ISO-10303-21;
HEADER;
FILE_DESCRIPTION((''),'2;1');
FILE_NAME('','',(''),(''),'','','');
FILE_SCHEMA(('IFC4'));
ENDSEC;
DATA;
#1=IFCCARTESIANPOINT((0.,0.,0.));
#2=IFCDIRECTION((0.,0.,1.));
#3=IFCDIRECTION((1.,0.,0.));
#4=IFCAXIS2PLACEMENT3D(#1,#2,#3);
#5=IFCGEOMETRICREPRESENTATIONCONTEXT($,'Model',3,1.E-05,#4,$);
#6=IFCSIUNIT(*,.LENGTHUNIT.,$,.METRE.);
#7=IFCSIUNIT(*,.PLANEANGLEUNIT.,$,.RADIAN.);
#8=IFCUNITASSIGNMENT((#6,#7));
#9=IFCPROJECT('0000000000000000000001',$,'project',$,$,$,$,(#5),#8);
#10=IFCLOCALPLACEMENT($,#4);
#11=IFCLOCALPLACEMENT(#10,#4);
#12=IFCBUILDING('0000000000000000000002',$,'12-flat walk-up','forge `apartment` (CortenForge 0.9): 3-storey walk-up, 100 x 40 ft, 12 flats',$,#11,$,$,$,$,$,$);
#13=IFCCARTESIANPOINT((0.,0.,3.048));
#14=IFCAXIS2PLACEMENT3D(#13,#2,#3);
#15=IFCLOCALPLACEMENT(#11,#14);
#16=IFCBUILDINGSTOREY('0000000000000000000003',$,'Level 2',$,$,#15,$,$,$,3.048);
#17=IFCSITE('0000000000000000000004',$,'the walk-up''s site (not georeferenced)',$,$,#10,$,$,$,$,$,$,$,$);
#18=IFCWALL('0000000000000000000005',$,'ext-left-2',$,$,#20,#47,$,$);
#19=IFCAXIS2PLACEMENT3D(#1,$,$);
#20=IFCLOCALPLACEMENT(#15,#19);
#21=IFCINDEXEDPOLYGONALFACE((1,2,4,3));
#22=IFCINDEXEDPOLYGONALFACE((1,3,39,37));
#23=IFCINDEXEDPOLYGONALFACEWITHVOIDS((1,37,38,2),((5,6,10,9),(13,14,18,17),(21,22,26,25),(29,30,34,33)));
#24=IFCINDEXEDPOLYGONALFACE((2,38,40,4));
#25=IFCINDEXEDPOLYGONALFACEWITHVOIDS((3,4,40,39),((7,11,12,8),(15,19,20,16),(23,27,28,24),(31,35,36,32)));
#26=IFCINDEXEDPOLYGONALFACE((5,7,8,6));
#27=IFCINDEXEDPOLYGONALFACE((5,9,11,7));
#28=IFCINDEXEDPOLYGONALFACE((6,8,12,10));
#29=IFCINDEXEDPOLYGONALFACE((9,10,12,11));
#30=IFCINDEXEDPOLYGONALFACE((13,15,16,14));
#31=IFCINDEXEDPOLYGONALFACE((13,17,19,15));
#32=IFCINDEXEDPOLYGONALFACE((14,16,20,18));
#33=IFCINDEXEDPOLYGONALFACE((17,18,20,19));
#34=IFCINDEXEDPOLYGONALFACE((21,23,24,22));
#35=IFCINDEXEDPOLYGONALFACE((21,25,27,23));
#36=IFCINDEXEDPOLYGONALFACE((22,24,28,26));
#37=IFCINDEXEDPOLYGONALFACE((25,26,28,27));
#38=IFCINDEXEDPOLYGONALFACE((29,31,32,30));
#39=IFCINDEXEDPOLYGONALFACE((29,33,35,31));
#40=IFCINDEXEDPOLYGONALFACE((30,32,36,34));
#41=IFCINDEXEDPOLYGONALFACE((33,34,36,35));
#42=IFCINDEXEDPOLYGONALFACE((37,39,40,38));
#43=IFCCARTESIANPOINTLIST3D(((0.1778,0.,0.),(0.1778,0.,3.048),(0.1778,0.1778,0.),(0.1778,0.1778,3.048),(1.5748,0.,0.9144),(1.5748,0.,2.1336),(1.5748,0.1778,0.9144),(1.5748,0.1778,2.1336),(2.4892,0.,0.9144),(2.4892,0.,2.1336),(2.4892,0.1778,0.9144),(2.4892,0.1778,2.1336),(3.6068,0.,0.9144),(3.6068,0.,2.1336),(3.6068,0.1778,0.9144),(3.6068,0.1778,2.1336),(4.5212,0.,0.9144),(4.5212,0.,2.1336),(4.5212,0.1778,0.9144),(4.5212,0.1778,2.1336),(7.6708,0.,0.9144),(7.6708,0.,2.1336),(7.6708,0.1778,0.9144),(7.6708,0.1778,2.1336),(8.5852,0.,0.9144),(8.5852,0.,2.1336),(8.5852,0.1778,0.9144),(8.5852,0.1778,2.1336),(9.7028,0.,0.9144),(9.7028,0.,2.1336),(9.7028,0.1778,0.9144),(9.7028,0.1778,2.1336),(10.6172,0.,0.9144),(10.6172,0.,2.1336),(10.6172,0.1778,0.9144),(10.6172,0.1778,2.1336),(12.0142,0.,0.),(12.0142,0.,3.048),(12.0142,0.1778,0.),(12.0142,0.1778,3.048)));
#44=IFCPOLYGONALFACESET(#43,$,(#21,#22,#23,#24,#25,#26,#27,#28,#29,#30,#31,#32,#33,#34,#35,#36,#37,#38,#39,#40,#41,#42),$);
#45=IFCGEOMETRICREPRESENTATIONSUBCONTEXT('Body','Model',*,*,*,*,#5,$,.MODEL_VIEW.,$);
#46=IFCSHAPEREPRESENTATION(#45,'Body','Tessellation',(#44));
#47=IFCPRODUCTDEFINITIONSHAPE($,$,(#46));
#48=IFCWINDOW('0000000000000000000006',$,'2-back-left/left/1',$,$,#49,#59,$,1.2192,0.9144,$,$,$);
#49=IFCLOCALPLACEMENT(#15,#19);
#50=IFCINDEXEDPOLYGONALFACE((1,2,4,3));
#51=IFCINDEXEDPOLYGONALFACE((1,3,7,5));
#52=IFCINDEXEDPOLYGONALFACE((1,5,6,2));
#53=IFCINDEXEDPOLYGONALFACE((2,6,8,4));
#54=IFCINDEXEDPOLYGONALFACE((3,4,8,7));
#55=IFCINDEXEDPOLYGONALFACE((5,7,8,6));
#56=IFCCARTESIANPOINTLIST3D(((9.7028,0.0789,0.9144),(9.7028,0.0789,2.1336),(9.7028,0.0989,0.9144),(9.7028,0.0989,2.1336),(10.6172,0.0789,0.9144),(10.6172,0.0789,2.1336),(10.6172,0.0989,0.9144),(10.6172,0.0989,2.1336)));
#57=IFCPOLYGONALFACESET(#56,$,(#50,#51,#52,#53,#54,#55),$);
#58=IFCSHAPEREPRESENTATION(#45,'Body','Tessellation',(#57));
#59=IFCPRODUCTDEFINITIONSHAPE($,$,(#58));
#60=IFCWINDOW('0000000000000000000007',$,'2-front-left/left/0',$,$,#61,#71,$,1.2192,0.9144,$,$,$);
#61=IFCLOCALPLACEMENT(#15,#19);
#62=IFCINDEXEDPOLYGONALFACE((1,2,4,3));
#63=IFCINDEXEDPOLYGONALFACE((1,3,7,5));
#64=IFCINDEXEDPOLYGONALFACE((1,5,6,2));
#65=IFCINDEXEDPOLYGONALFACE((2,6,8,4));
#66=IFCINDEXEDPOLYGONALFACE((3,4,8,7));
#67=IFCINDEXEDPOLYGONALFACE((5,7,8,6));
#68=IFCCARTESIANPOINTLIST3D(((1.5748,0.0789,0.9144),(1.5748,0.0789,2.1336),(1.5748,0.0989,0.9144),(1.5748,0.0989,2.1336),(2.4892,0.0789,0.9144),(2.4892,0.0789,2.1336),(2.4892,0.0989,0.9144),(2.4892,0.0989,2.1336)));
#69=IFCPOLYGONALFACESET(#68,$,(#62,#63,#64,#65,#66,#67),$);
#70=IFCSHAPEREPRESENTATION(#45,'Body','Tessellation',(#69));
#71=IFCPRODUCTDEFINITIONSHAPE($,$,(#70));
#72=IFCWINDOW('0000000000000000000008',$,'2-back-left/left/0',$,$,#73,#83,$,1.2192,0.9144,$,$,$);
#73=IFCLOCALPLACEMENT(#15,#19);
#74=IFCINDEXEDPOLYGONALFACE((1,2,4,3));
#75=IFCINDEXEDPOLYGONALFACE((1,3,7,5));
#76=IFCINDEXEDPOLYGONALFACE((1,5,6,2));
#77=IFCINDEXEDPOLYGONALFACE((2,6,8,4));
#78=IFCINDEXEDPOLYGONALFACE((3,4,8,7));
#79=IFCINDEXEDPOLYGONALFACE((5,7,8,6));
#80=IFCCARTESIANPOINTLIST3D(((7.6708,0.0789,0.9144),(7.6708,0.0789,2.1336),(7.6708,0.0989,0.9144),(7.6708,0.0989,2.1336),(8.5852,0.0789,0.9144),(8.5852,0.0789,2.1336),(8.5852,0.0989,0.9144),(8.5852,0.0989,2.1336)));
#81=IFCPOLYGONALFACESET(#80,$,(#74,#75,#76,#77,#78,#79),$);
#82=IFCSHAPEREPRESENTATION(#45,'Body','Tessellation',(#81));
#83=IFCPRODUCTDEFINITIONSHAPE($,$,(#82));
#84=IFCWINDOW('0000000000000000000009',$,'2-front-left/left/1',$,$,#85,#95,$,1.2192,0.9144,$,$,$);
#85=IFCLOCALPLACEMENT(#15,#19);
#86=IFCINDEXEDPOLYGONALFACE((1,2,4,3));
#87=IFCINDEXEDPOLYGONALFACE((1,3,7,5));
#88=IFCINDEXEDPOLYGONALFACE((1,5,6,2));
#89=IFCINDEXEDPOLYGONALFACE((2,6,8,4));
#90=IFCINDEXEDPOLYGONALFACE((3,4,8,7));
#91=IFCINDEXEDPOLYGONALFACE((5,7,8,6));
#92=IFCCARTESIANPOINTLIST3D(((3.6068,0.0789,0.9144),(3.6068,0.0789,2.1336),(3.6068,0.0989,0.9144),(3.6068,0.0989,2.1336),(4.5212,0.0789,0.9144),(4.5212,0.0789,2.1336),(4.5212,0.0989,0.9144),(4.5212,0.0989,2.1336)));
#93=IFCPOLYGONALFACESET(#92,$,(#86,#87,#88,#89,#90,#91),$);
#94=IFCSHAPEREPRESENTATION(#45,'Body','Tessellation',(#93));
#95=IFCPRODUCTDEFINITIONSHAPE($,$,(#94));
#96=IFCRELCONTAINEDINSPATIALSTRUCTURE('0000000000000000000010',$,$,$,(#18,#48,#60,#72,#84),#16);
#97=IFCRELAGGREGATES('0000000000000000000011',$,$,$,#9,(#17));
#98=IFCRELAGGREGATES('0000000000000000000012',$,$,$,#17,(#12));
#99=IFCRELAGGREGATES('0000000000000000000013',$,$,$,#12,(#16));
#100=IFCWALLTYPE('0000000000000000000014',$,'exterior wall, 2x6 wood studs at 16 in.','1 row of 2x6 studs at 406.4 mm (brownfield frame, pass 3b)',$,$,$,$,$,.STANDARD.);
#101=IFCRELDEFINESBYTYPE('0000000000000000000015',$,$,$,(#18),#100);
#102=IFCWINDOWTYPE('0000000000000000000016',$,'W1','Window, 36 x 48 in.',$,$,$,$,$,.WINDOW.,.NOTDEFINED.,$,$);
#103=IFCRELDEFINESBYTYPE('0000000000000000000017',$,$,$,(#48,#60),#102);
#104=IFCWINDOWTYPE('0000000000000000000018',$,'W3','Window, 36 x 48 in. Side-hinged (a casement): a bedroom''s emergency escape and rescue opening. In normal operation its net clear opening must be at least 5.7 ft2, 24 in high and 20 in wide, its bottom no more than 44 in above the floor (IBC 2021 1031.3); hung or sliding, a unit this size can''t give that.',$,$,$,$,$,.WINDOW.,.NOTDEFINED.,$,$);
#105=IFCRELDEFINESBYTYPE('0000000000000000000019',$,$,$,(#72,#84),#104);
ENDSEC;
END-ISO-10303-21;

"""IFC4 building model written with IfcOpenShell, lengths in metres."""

from ifc_helpers import new_model, si_unit, frame, frame_2d, origin, origin_with_axes, place, context, subcontext, project, spatial, rectangle, extrude, type_object, element, fill, save


model = new_model("IFC4")

# Units and contexts
model_context = context("Model", 3, precision=1e-05, world=origin_with_axes())
body_context = subcontext(model_context, "Body", "Model", "MODEL_VIEW")
ifc_project = project(units=[si_unit("LENGTHUNIT", "METRE"), si_unit("PLANEANGLEUNIT", "RADIAN")], contexts=[model_context])

# Site, building, storey
site_placement = place(None, origin_with_axes())
site = spatial("IfcSite", under=ifc_project, at=site_placement, Name="the walk-up's site (not georeferenced)")
building_placement = place(site_placement, origin_with_axes())
building = spatial("IfcBuilding", under=site, at=building_placement, Name="12-flat walk-up", Description="forge `apartment` (CortenForge 0.9): 3-storey walk-up, 100 x 40 ft, 12 flats")
storey_placement = place(building_placement, frame((0.0, 0.0, 3.048), z_axis=(0.0, 0.0, 1.0), x_axis=(1.0, 0.0, 0.0)))
storey = spatial("IfcBuildingStorey", under=building, at=storey_placement, Name="Level 2", Elevation=3.048)

# Shared definitions
wall_type = type_object("IfcWallType", Name="exterior wall, 2x6 wood studs at 16 in.", Description="1 row of 2x6 studs at 406.4 mm (brownfield frame, pass 3b)", PredefinedType="STANDARD")
window_type_1 = type_object("IfcWindowType", Name="W1", Description="Window, 36 x 48 in.", PartitioningType="NOTDEFINED", PredefinedType="WINDOW")
window_type_2 = type_object("IfcWindowType", Name="W3", Description="Window, 36 x 48 in. Side-hinged (a casement): a bedroom's emergency escape and rescue opening. In normal operation its net clear opening must be at least 5.7 ft2, 24 in high and 20 in wide, its bottom no more than 44 in above the floor (IBC 2021 1031.3); hung or sliding, a unit this size can't give that.", PartitioningType="NOTDEFINED", PredefinedType="WINDOW")

# Wall, openings, windows
wall_1_placement = place(storey_placement, frame((0.1778, 0.0, 0.0), z_axis=(0.0, 0.0, 1.0), x_axis=(1.0, 0.0, 0.0)))
wall_1 = element("IfcWall", 1, at=wall_1_placement, inside=storey, type_object=wall_type, Name="ext-left-2", context=body_context, shape_type="SweptSolid", body=[
    extrude(rectangle(XDim=11.8364, YDim=0.1778, at=frame_2d((5.9182, 0.0889))), origin(), (0.0, 0.0, 1.0), 3.048),
])
opening_1_placement = place(wall_1_placement, frame((7.493, 0.0, 0.9144), z_axis=(0.0, 0.0, 1.0), x_axis=(1.0, 0.0, 0.0)))
opening_1 = element("IfcOpeningElement", 2, at=opening_1_placement, cuts=wall_1, PredefinedType="OPENING", context=body_context, shape_type="SweptSolid", body=[
    extrude(rectangle(XDim=0.9144, YDim=0.1778, at=frame_2d((0.4572, 0.0889))), origin(), (0.0, 0.0, 1.0), 1.2192),
])
opening_2_placement = place(wall_1_placement, frame((9.525, 0.0, 0.9144), z_axis=(0.0, 0.0, 1.0), x_axis=(1.0, 0.0, 0.0)))
opening_2 = element("IfcOpeningElement", 3, at=opening_2_placement, cuts=wall_1, PredefinedType="OPENING", context=body_context, shape_type="SweptSolid", body=[
    extrude(rectangle(XDim=0.9144, YDim=0.1778, at=frame_2d((0.4572, 0.0889))), origin(), (0.0, 0.0, 1.0), 1.2192),
])
opening_3_placement = place(wall_1_placement, frame((1.397, 0.0, 0.9144), z_axis=(0.0, 0.0, 1.0), x_axis=(1.0, 0.0, 0.0)))
opening_3 = element("IfcOpeningElement", 4, at=opening_3_placement, cuts=wall_1, PredefinedType="OPENING", context=body_context, shape_type="SweptSolid", body=[
    extrude(rectangle(XDim=0.9144, YDim=0.1778, at=frame_2d((0.4572, 0.0889))), origin(), (0.0, 0.0, 1.0), 1.2192),
])
opening_4_placement = place(wall_1_placement, frame((3.429, 0.0, 0.9144), z_axis=(0.0, 0.0, 1.0), x_axis=(1.0, 0.0, 0.0)))
opening_4 = element("IfcOpeningElement", 5, at=opening_4_placement, cuts=wall_1, PredefinedType="OPENING", context=body_context, shape_type="SweptSolid", body=[
    extrude(rectangle(XDim=0.9144, YDim=0.1778, at=frame_2d((0.4572, 0.0889))), origin(), (0.0, 0.0, 1.0), 1.2192),
])
window_1_placement = place(opening_2_placement, frame((0.0, 0.0789, 0.0), z_axis=(0.0, 0.0, 1.0), x_axis=(1.0, 0.0, 0.0)))
window_1 = element("IfcWindow", 6, at=window_1_placement, inside=storey, type_object=window_type_1, Name="2-back-left/left/1", OverallHeight=1.2192, OverallWidth=0.9144, context=body_context, shape_type="SweptSolid", body=[
    extrude(rectangle(XDim=0.9144, YDim=0.02, at=frame_2d((0.4572, 0.01))), origin(), (0.0, 0.0, 1.0), 1.2192),
])
fill(opening_2, window_1)
window_2_placement = place(opening_3_placement, frame((0.0, 0.0789, 0.0), z_axis=(0.0, 0.0, 1.0), x_axis=(1.0, 0.0, 0.0)))
window_2 = element("IfcWindow", 7, at=window_2_placement, inside=storey, type_object=window_type_1, Name="2-front-left/left/0", OverallHeight=1.2192, OverallWidth=0.9144, context=body_context, shape_type="SweptSolid", body=[
    extrude(rectangle(XDim=0.9144, YDim=0.02, at=frame_2d((0.4572, 0.01))), origin(), (0.0, 0.0, 1.0), 1.2192),
])
fill(opening_3, window_2)
window_3_placement = place(opening_1_placement, frame((0.0, 0.0789, 0.0), z_axis=(0.0, 0.0, 1.0), x_axis=(1.0, 0.0, 0.0)))
window_3 = element("IfcWindow", 8, at=window_3_placement, inside=storey, type_object=window_type_2, Name="2-back-left/left/0", OverallHeight=1.2192, OverallWidth=0.9144, context=body_context, shape_type="SweptSolid", body=[
    extrude(rectangle(XDim=0.9144, YDim=0.02, at=frame_2d((0.4572, 0.01))), origin(), (0.0, 0.0, 1.0), 1.2192),
])
fill(opening_1, window_3)
window_4_placement = place(opening_4_placement, frame((0.0, 0.0789, 0.0), z_axis=(0.0, 0.0, 1.0), x_axis=(1.0, 0.0, 0.0)))
window_4 = element("IfcWindow", 9, at=window_4_placement, inside=storey, type_object=window_type_2, Name="2-front-left/left/1", OverallHeight=1.2192, OverallWidth=0.9144, context=body_context, shape_type="SweptSolid", body=[
    extrude(rectangle(XDim=0.9144, YDim=0.02, at=frame_2d((0.4572, 0.01))), origin(), (0.0, 0.0, 1.0), 1.2192),
])
fill(opening_4, window_4)

save(model, "model.ifc")
